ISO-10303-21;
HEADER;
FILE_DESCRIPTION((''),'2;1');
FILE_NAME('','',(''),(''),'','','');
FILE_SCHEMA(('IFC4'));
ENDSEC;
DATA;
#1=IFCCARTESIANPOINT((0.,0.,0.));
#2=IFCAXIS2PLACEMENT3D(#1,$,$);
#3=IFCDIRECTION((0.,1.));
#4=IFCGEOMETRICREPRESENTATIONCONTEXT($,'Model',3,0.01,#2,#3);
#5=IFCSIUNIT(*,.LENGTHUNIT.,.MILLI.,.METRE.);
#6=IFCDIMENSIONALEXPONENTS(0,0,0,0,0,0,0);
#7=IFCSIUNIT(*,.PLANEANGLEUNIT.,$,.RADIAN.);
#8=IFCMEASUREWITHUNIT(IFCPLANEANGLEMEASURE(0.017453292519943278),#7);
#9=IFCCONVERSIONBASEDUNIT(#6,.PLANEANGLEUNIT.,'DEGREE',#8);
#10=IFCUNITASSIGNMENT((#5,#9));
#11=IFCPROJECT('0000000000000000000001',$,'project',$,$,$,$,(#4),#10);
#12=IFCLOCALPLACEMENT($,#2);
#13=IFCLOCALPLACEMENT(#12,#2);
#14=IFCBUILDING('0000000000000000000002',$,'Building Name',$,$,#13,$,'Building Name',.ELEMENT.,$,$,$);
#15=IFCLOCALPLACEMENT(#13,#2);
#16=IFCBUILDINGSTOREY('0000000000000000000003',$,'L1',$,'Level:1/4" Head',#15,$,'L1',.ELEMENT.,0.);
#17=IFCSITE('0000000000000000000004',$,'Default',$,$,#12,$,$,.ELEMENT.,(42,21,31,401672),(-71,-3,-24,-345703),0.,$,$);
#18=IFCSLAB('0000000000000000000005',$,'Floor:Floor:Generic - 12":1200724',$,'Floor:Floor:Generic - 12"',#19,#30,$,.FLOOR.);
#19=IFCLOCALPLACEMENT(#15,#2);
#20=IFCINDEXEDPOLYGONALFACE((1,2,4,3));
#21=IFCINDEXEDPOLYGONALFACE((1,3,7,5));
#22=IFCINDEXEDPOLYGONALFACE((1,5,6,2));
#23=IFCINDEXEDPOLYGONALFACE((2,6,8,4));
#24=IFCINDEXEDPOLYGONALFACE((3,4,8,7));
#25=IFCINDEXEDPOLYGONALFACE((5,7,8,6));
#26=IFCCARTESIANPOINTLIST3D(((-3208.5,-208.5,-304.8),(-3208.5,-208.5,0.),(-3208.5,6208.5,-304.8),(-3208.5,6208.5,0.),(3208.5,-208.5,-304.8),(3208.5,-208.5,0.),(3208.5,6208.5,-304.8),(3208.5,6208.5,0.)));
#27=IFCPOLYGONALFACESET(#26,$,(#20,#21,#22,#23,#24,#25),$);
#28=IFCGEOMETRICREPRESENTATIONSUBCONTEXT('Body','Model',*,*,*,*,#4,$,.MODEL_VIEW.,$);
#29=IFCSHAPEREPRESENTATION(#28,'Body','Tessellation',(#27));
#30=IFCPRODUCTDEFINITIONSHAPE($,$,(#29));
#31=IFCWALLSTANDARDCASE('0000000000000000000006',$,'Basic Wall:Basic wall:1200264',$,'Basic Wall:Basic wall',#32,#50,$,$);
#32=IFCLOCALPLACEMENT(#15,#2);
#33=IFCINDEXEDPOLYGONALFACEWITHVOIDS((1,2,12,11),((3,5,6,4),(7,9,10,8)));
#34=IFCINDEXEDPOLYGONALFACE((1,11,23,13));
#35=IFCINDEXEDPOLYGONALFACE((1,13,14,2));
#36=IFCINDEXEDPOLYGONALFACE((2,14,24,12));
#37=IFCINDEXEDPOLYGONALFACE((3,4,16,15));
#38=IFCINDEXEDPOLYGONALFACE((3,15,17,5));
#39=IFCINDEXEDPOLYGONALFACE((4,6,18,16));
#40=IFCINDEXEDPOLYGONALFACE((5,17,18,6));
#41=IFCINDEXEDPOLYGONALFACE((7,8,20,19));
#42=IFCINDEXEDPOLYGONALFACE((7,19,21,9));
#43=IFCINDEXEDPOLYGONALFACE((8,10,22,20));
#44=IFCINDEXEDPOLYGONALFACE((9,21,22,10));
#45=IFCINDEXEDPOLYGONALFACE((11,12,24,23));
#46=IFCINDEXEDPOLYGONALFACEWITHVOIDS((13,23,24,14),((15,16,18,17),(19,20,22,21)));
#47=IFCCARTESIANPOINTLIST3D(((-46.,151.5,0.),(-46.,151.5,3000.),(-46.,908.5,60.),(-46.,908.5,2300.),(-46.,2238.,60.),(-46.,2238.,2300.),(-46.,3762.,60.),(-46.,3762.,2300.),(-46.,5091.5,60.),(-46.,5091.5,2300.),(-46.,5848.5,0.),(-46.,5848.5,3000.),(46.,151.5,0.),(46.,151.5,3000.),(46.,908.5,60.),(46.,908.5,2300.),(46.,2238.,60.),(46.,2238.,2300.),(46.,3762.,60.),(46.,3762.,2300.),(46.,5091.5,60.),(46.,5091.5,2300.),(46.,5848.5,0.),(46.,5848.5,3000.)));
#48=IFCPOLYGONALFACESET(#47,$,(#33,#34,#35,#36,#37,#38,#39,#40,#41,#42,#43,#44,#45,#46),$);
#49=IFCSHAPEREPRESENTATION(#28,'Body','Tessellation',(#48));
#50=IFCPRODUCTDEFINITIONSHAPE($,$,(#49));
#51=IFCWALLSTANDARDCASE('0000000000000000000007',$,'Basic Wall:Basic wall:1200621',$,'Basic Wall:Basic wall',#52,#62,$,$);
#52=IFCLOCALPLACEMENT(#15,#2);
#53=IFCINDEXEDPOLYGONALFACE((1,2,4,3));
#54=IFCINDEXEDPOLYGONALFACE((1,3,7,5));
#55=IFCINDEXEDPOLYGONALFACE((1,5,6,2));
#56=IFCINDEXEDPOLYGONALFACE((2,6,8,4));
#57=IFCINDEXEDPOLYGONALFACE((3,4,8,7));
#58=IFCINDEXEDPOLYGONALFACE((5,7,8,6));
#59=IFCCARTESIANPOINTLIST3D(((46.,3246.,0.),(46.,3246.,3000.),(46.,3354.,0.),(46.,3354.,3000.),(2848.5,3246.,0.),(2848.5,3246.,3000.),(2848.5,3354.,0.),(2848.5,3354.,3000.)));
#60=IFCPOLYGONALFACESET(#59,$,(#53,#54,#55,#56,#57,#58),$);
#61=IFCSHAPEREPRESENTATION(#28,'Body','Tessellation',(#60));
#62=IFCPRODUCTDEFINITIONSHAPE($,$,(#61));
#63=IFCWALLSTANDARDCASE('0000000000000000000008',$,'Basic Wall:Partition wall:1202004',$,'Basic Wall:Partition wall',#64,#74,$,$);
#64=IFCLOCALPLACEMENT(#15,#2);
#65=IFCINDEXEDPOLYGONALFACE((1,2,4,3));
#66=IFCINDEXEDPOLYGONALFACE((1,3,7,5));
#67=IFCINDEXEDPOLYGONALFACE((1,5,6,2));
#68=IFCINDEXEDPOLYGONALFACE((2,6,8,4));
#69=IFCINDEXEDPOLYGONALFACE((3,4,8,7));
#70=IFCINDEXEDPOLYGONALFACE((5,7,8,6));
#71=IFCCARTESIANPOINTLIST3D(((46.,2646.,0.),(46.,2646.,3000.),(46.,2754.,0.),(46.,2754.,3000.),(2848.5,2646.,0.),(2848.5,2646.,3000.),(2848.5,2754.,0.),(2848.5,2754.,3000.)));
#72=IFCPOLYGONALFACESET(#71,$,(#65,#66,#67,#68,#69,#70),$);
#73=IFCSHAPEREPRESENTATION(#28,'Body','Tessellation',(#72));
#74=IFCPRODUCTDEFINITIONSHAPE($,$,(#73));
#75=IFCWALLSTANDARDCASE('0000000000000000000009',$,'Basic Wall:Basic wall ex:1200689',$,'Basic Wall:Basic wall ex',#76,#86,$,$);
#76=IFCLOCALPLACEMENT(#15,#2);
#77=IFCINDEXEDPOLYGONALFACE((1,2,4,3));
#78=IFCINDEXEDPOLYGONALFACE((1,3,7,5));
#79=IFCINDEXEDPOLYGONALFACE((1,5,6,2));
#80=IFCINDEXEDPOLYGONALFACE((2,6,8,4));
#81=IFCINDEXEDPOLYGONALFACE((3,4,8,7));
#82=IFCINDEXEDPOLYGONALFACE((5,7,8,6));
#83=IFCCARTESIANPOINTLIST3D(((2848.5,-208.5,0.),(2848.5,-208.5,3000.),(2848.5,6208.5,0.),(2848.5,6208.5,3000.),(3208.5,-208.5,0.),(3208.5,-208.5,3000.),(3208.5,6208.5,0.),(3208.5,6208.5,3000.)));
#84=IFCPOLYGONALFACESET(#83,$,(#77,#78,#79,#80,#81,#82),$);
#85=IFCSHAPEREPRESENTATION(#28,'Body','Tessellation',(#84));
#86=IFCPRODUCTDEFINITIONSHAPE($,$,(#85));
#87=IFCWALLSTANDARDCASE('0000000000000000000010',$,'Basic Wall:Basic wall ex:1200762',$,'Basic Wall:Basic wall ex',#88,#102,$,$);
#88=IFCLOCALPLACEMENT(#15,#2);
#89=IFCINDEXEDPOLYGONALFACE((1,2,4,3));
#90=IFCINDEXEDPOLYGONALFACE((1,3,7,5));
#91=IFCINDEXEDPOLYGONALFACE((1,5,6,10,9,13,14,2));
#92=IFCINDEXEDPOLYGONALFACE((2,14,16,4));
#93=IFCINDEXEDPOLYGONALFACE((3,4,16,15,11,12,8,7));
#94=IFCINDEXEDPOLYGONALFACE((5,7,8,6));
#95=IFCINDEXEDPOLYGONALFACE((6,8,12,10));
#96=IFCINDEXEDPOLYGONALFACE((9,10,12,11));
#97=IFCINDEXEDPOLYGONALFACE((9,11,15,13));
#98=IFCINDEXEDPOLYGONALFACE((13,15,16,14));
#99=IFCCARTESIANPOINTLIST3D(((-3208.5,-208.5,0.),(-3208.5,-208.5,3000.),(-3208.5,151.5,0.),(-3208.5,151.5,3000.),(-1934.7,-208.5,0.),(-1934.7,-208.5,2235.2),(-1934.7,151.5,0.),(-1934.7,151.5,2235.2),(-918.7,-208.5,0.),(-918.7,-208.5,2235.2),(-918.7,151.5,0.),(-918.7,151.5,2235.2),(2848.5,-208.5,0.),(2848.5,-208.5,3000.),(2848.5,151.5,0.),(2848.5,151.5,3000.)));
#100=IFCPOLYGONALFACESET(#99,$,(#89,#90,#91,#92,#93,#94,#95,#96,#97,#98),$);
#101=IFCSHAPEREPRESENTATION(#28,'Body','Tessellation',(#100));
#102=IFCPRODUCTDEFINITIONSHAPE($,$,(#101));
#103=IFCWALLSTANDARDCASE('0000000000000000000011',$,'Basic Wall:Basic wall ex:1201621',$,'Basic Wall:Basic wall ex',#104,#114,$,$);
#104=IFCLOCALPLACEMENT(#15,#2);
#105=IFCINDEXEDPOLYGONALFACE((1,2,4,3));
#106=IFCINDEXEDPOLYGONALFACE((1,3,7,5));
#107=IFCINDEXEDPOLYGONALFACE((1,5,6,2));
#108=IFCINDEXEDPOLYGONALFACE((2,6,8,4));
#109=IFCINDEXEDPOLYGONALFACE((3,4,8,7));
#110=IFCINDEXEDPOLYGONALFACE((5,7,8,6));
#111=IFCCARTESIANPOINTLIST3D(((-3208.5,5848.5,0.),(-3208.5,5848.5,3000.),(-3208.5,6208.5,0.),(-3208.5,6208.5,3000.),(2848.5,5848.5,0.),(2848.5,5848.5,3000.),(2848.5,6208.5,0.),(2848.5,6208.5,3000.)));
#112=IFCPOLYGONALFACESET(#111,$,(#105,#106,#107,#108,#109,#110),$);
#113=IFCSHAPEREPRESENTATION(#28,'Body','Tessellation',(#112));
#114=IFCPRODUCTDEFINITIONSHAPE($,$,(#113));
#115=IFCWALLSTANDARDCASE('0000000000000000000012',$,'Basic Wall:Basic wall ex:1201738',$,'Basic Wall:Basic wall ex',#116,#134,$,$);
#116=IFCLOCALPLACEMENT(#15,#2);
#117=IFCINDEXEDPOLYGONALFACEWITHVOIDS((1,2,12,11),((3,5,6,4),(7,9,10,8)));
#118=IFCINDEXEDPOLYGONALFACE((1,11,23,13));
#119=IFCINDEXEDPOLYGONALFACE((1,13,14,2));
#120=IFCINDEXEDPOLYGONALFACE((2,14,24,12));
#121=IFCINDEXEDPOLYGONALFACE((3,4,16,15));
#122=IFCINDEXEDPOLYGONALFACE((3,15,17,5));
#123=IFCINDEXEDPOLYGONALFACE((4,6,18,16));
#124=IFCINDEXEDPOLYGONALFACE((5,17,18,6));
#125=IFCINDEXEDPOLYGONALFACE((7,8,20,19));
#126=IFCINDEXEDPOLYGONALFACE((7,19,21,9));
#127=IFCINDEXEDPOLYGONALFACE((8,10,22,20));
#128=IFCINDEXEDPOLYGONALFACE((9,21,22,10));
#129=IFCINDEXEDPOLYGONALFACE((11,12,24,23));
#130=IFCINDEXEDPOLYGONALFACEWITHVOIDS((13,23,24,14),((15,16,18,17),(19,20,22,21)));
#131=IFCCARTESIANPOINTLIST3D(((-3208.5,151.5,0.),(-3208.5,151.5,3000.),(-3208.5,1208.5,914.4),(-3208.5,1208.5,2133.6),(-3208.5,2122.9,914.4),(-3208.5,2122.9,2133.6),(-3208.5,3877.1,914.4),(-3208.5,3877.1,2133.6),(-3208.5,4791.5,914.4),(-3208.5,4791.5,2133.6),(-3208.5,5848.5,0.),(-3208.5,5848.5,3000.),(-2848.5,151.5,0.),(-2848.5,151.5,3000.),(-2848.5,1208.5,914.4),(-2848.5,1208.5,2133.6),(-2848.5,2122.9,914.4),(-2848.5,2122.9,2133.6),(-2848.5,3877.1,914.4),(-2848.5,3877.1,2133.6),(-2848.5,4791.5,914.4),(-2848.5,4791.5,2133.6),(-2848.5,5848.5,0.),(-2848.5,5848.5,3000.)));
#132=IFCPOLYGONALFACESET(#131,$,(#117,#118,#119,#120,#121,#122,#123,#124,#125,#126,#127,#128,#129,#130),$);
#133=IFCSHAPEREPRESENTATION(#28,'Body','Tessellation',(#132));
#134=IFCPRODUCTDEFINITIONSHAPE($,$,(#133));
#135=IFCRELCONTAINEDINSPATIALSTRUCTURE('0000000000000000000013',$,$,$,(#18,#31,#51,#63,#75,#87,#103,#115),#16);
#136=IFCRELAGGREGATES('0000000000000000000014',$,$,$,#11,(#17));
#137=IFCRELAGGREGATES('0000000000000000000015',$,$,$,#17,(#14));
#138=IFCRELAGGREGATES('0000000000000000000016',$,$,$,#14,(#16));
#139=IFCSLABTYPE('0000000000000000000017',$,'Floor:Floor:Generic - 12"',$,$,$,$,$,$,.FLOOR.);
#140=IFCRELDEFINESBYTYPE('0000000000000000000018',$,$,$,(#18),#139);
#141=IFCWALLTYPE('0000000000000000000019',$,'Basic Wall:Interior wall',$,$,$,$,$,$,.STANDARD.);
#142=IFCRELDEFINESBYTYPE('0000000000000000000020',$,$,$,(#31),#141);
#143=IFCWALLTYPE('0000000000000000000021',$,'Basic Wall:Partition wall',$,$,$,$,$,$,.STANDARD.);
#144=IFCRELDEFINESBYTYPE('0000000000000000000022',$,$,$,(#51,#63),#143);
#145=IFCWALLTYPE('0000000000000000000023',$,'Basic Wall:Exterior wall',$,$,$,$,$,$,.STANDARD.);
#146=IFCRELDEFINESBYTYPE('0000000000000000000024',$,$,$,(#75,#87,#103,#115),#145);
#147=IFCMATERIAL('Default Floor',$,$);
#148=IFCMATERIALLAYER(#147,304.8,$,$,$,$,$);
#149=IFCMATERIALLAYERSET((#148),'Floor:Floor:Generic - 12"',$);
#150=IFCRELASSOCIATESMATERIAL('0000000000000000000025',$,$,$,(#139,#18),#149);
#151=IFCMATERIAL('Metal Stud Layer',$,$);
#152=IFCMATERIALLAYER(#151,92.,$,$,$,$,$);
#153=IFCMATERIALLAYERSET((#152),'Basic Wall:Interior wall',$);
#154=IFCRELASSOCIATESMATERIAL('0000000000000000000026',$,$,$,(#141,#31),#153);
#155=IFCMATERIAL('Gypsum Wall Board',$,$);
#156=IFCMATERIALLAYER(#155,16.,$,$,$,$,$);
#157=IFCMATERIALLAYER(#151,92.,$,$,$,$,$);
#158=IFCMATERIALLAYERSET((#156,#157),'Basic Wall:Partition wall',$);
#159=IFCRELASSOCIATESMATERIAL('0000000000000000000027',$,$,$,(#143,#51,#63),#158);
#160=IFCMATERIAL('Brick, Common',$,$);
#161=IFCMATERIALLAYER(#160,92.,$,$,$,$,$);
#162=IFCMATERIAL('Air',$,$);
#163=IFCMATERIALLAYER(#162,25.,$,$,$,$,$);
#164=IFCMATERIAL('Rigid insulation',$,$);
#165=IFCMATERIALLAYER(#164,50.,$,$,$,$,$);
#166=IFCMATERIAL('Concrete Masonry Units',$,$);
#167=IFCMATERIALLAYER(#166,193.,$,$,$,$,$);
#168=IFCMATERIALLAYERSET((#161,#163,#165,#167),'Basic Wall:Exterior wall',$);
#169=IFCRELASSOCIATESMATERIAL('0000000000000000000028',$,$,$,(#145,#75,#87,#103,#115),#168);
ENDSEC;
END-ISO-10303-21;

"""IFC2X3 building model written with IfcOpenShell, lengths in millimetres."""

from ifc_helpers import new_model, entity, si_unit, converted_unit, direction, frame, frame_2d, origin, origin_2d_with_axis, place, context, subcontext, project, spatial, rectangle, extrude, material, layer, layer_set, layer_usage, type_object, element, save


model = new_model("IFC2X3")

# Units and contexts
model_context = context("Model", 3, precision=0.01, world=origin(), true_north=direction((0.0, 1.0)))
body_context = subcontext(model_context, "Body", "Model", "MODEL_VIEW")
ifc_project = project(units=[si_unit("LENGTHUNIT", "METRE", prefix="MILLI"), converted_unit("PLANEANGLEUNIT", "DEGREE", entity("IfcPlaneAngleMeasure", 0.017453292519943278), si_unit("PLANEANGLEUNIT", "RADIAN"), dimensions=[0, 0, 0, 0, 0, 0, 0])], contexts=[model_context])

# Site, building, storey
site_placement = place(None, origin())
site = spatial("IfcSite", under=ifc_project, at=site_placement, Name="Default", CompositionType="ELEMENT", RefLatitude=(42, 21, 31, 401672), RefLongitude=(-71, -3, -24, -345703), RefElevation=0.0)
building_placement = place(site_placement, origin())
building = spatial("IfcBuilding", under=site, at=building_placement, Name="Building Name", LongName="Building Name", CompositionType="ELEMENT")
storey_placement = place(building_placement, origin())
storey = spatial("IfcBuildingStorey", under=building, at=storey_placement, Name="L1", ObjectType="Level:1/4\" Head", LongName="L1", CompositionType="ELEMENT", Elevation=0.0)

# Slab
ifc_material_1 = material(Name="Default Floor")
ifc_layer_1 = layer(ifc_material_1, 304.8)
ifc_layer_set_1 = layer_set([ifc_layer_1], Name="Floor:Floor:Generic - 12\"")
ifc_layer_usage_1 = layer_usage(ifc_layer_set_1, "AXIS3", "POSITIVE", 0.0)
slab_type = type_object("IfcSlabType", Name="Floor:Floor:Generic - 12\"", PredefinedType="FLOOR", material=ifc_layer_set_1)
slab_placement = place(storey_placement, origin())
element("IfcSlab", 1, at=slab_placement, inside=storey, type_object=slab_type, material=ifc_layer_usage_1, Name="Floor:Floor:Generic - 12\":1200724", ObjectType="Floor:Floor:Generic - 12\"", PredefinedType="FLOOR", context=body_context, shape_type="SweptSolid", body=[
    extrude(rectangle(XDim=6417.0, YDim=6417.0, at=origin_2d_with_axis()), frame((0.0, 3000.0, 0.0), z_axis=(0.0, 0.0, -1.0), x_axis=(0.0, 1.0, 0.0)), (0.0, 0.0, 1.0), 304.8),
])

# Wall, openings
ifc_material_2 = material(Name="Metal Stud Layer")
ifc_layer_2 = layer(ifc_material_2, 92.0)
ifc_layer_set_2 = layer_set([ifc_layer_2], Name="Basic Wall:Interior wall")
ifc_layer_usage_2 = layer_usage(ifc_layer_set_2, "AXIS2", "NEGATIVE", 46.0)
wall_type_1 = type_object("IfcWallType", Name="Basic Wall:Interior wall", PredefinedType="STANDARD", material=ifc_layer_set_2)
wall_1_placement = place(storey_placement, frame((0.0, 5848.5, 0.0), z_axis=(0.0, 0.0, 1.0), x_axis=(0.0, -1.0, 0.0)))
wall_1 = element("IfcWallStandardCase", 2, at=wall_1_placement, inside=storey, type_object=wall_type_1, material=ifc_layer_usage_2, Name="Basic Wall:Basic wall:1200264", ObjectType="Basic Wall:Basic wall", context=body_context, shape_type="SweptSolid", body=[
    extrude(rectangle(XDim=5697.0, YDim=92.0, at=frame_2d((2848.5, 0.0), x_axis=(-1.0, 0.0))), origin(), (0.0, 0.0, 1.0), 3000.0),
])
opening_1_placement = place(wall_1_placement, origin())
element("IfcOpeningElement", 3, at=opening_1_placement, cuts=wall_1, ObjectType="Opening", context=body_context, shape_type="SweptSolid", body=[
    extrude(rectangle(XDim=2240.0, YDim=1329.5, at=origin_2d_with_axis()), frame((1421.8, -46.0, 1180.0), z_axis=(0.0, 1.0, 0.0), x_axis=(0.0, 0.0, -1.0)), (0.0, 0.0, 1.0), 92.0),
])
opening_2_placement = place(wall_1_placement, origin())
element("IfcOpeningElement", 4, at=opening_2_placement, cuts=wall_1, ObjectType="Opening", context=body_context, shape_type="SweptSolid", body=[
    extrude(rectangle(XDim=2240.0, YDim=1329.5, at=origin_2d_with_axis()), frame((4275.2, -46.0, 1180.0), z_axis=(0.0, 1.0, 0.0), x_axis=(0.0, 0.0, -1.0)), (0.0, 0.0, 1.0), 92.0),
])

# Walls
ifc_material_3 = material(Name="Gypsum Wall Board")
ifc_layer_3 = layer(ifc_material_3, 16.0)
ifc_layer_4 = layer(ifc_material_2, 92.0)
ifc_layer_set_3 = layer_set([ifc_layer_3, ifc_layer_4], Name="Basic Wall:Partition wall")
ifc_layer_usage_3 = layer_usage(ifc_layer_set_3, "AXIS2", "NEGATIVE", 54.0)
wall_type_2 = type_object("IfcWallType", Name="Basic Wall:Partition wall", PredefinedType="STANDARD", material=ifc_layer_set_3)
wall_2_placement = place(storey_placement, frame((46.0, 3300.0, 0.0)))
element("IfcWallStandardCase", 5, at=wall_2_placement, inside=storey, type_object=wall_type_2, material=ifc_layer_usage_3, Name="Basic Wall:Basic wall:1200621", ObjectType="Basic Wall:Basic wall", context=body_context, shape_type="SweptSolid", body=[
    extrude(rectangle(XDim=2802.5, YDim=108.0, at=frame_2d((1401.2, 0.0), x_axis=(-1.0, 0.0))), origin(), (0.0, 0.0, 1.0), 3000.0),
])
ifc_layer_usage_4 = layer_usage(ifc_layer_set_3, "AXIS2", "POSITIVE", -54.0)
wall_3_placement = place(storey_placement, frame((46.0, 2700.0, 0.0)))
element("IfcWallStandardCase", 6, at=wall_3_placement, inside=storey, type_object=wall_type_2, material=ifc_layer_usage_4, Name="Basic Wall:Partition wall:1202004", ObjectType="Basic Wall:Partition wall", context=body_context, shape_type="SweptSolid", body=[
    extrude(rectangle(XDim=2802.5, YDim=108.0, at=frame_2d((1401.2, 0.0), x_axis=(-1.0, 0.0))), origin(), (0.0, 0.0, 1.0), 3000.0),
])
ifc_material_4 = material(Name="Brick, Common")
ifc_layer_5 = layer(ifc_material_4, 92.0)
ifc_material_5 = material(Name="Air")
ifc_layer_6 = layer(ifc_material_5, 25.0)
ifc_material_6 = material(Name="Rigid insulation")
ifc_layer_7 = layer(ifc_material_6, 50.0)
ifc_material_7 = material(Name="Concrete Masonry Units")
ifc_layer_8 = layer(ifc_material_7, 193.0)
ifc_layer_set_4 = layer_set([ifc_layer_5, ifc_layer_6, ifc_layer_7, ifc_layer_8], Name="Basic Wall:Exterior wall")
ifc_layer_usage_5 = layer_usage(ifc_layer_set_4, "AXIS2", "NEGATIVE", 180.0)
wall_type_3 = type_object("IfcWallType", Name="Basic Wall:Exterior wall", PredefinedType="STANDARD", material=ifc_layer_set_4)
wall_4_placement = place(storey_placement, frame((3028.5, 6208.5, 0.0), z_axis=(0.0, 0.0, 1.0), x_axis=(0.0, -1.0, 0.0)))
element("IfcWallStandardCase", 7, at=wall_4_placement, inside=storey, type_object=wall_type_3, material=ifc_layer_usage_5, Name="Basic Wall:Basic wall ex:1200689", ObjectType="Basic Wall:Basic wall ex", context=body_context, shape_type="SweptSolid", body=[
    extrude(rectangle(XDim=6417.0, YDim=360.0, at=frame_2d((3208.5, 0.0), x_axis=(-1.0, 0.0))), origin(), (0.0, 0.0, 1.0), 3000.0),
])

# Wall, opening
ifc_layer_usage_6 = layer_usage(ifc_layer_set_4, "AXIS2", "NEGATIVE", 180.0)
wall_5_placement = place(storey_placement, frame((2848.5, -28.5, 0.0), z_axis=(0.0, 0.0, 1.0), x_axis=(-1.0, 0.0, 0.0)))
wall_5 = element("IfcWallStandardCase", 8, at=wall_5_placement, inside=storey, type_object=wall_type_3, material=ifc_layer_usage_6, Name="Basic Wall:Basic wall ex:1200762", ObjectType="Basic Wall:Basic wall ex", context=body_context, shape_type="SweptSolid", body=[
    extrude(rectangle(XDim=6057.0, YDim=360.0, at=frame_2d((3028.5, 0.0), x_axis=(1.0, 0.0))), origin(), (0.0, 0.0, 1.0), 3000.0),
])
opening_3_placement = place(wall_5_placement, frame((3767.2, -180.0, 0.0)))
element("IfcOpeningElement", 9, at=opening_3_placement, cuts=wall_5, ObjectType="Opening", context=body_context, shape_type="SweptSolid", body=[
    extrude(rectangle(XDim=2235.2, YDim=1016.0, at=frame_2d((1117.6, 508.0), x_axis=(1.0, 0.0))), frame((0.0, 0.0, 0.0), z_axis=(0.0, 1.0, 0.0), x_axis=(0.0, 0.0, 1.0)), (0.0, 0.0, 1.0), 360.0),
])

# Wall
ifc_layer_usage_7 = layer_usage(ifc_layer_set_4, "AXIS2", "NEGATIVE", 180.0)
wall_6_placement = place(storey_placement, frame((-3208.5, 6028.5, 0.0)))
element("IfcWallStandardCase", 10, at=wall_6_placement, inside=storey, type_object=wall_type_3, material=ifc_layer_usage_7, Name="Basic Wall:Basic wall ex:1201621", ObjectType="Basic Wall:Basic wall ex", context=body_context, shape_type="SweptSolid", body=[
    extrude(rectangle(XDim=6057.0, YDim=360.0, at=frame_2d((3028.5, 0.0), x_axis=(-1.0, 0.0))), origin(), (0.0, 0.0, 1.0), 3000.0),
])

# Wall, openings
ifc_layer_usage_8 = layer_usage(ifc_layer_set_4, "AXIS2", "NEGATIVE", 180.0)
wall_7_placement = place(storey_placement, frame((-3028.5, 151.5, 0.0), z_axis=(0.0, 0.0, 1.0), x_axis=(0.0, 1.0, 0.0)))
wall_7 = element("IfcWallStandardCase", 11, at=wall_7_placement, inside=storey, type_object=wall_type_3, material=ifc_layer_usage_8, Name="Basic Wall:Basic wall ex:1201738", ObjectType="Basic Wall:Basic wall ex", context=body_context, shape_type="SweptSolid", body=[
    extrude(rectangle(XDim=5697.0, YDim=360.0, at=frame_2d((2848.5, 0.0), x_axis=(-1.0, 0.0))), origin(), (0.0, 0.0, 1.0), 3000.0),
])
opening_4_placement = place(wall_7_placement, frame((3725.6, -180.0, 914.4)))
element("IfcOpeningElement", 12, at=opening_4_placement, cuts=wall_7, ObjectType="Opening", context=body_context, shape_type="SweptSolid", body=[
    extrude(rectangle(XDim=1219.2, YDim=914.4, at=frame_2d((609.6, 457.2), x_axis=(-1.0, 0.0))), frame((0.0, 0.0, 0.0), z_axis=(0.0, 1.0, 0.0), x_axis=(0.0, 0.0, 1.0)), (0.0, 0.0, 1.0), 360.0),
])
opening_5_placement = place(wall_7_placement, frame((1057.0, -180.0, 914.4)))
element("IfcOpeningElement", 13, at=opening_5_placement, cuts=wall_7, ObjectType="Opening", context=body_context, shape_type="SweptSolid", body=[
    extrude(rectangle(XDim=1219.2, YDim=914.4, at=frame_2d((609.6, 457.2), x_axis=(-1.0, 0.0))), frame((0.0, 0.0, 0.0), z_axis=(0.0, 1.0, 0.0), x_axis=(0.0, 0.0, 1.0)), (0.0, 0.0, 1.0), 360.0),
])

save(model, "model.ifc")
